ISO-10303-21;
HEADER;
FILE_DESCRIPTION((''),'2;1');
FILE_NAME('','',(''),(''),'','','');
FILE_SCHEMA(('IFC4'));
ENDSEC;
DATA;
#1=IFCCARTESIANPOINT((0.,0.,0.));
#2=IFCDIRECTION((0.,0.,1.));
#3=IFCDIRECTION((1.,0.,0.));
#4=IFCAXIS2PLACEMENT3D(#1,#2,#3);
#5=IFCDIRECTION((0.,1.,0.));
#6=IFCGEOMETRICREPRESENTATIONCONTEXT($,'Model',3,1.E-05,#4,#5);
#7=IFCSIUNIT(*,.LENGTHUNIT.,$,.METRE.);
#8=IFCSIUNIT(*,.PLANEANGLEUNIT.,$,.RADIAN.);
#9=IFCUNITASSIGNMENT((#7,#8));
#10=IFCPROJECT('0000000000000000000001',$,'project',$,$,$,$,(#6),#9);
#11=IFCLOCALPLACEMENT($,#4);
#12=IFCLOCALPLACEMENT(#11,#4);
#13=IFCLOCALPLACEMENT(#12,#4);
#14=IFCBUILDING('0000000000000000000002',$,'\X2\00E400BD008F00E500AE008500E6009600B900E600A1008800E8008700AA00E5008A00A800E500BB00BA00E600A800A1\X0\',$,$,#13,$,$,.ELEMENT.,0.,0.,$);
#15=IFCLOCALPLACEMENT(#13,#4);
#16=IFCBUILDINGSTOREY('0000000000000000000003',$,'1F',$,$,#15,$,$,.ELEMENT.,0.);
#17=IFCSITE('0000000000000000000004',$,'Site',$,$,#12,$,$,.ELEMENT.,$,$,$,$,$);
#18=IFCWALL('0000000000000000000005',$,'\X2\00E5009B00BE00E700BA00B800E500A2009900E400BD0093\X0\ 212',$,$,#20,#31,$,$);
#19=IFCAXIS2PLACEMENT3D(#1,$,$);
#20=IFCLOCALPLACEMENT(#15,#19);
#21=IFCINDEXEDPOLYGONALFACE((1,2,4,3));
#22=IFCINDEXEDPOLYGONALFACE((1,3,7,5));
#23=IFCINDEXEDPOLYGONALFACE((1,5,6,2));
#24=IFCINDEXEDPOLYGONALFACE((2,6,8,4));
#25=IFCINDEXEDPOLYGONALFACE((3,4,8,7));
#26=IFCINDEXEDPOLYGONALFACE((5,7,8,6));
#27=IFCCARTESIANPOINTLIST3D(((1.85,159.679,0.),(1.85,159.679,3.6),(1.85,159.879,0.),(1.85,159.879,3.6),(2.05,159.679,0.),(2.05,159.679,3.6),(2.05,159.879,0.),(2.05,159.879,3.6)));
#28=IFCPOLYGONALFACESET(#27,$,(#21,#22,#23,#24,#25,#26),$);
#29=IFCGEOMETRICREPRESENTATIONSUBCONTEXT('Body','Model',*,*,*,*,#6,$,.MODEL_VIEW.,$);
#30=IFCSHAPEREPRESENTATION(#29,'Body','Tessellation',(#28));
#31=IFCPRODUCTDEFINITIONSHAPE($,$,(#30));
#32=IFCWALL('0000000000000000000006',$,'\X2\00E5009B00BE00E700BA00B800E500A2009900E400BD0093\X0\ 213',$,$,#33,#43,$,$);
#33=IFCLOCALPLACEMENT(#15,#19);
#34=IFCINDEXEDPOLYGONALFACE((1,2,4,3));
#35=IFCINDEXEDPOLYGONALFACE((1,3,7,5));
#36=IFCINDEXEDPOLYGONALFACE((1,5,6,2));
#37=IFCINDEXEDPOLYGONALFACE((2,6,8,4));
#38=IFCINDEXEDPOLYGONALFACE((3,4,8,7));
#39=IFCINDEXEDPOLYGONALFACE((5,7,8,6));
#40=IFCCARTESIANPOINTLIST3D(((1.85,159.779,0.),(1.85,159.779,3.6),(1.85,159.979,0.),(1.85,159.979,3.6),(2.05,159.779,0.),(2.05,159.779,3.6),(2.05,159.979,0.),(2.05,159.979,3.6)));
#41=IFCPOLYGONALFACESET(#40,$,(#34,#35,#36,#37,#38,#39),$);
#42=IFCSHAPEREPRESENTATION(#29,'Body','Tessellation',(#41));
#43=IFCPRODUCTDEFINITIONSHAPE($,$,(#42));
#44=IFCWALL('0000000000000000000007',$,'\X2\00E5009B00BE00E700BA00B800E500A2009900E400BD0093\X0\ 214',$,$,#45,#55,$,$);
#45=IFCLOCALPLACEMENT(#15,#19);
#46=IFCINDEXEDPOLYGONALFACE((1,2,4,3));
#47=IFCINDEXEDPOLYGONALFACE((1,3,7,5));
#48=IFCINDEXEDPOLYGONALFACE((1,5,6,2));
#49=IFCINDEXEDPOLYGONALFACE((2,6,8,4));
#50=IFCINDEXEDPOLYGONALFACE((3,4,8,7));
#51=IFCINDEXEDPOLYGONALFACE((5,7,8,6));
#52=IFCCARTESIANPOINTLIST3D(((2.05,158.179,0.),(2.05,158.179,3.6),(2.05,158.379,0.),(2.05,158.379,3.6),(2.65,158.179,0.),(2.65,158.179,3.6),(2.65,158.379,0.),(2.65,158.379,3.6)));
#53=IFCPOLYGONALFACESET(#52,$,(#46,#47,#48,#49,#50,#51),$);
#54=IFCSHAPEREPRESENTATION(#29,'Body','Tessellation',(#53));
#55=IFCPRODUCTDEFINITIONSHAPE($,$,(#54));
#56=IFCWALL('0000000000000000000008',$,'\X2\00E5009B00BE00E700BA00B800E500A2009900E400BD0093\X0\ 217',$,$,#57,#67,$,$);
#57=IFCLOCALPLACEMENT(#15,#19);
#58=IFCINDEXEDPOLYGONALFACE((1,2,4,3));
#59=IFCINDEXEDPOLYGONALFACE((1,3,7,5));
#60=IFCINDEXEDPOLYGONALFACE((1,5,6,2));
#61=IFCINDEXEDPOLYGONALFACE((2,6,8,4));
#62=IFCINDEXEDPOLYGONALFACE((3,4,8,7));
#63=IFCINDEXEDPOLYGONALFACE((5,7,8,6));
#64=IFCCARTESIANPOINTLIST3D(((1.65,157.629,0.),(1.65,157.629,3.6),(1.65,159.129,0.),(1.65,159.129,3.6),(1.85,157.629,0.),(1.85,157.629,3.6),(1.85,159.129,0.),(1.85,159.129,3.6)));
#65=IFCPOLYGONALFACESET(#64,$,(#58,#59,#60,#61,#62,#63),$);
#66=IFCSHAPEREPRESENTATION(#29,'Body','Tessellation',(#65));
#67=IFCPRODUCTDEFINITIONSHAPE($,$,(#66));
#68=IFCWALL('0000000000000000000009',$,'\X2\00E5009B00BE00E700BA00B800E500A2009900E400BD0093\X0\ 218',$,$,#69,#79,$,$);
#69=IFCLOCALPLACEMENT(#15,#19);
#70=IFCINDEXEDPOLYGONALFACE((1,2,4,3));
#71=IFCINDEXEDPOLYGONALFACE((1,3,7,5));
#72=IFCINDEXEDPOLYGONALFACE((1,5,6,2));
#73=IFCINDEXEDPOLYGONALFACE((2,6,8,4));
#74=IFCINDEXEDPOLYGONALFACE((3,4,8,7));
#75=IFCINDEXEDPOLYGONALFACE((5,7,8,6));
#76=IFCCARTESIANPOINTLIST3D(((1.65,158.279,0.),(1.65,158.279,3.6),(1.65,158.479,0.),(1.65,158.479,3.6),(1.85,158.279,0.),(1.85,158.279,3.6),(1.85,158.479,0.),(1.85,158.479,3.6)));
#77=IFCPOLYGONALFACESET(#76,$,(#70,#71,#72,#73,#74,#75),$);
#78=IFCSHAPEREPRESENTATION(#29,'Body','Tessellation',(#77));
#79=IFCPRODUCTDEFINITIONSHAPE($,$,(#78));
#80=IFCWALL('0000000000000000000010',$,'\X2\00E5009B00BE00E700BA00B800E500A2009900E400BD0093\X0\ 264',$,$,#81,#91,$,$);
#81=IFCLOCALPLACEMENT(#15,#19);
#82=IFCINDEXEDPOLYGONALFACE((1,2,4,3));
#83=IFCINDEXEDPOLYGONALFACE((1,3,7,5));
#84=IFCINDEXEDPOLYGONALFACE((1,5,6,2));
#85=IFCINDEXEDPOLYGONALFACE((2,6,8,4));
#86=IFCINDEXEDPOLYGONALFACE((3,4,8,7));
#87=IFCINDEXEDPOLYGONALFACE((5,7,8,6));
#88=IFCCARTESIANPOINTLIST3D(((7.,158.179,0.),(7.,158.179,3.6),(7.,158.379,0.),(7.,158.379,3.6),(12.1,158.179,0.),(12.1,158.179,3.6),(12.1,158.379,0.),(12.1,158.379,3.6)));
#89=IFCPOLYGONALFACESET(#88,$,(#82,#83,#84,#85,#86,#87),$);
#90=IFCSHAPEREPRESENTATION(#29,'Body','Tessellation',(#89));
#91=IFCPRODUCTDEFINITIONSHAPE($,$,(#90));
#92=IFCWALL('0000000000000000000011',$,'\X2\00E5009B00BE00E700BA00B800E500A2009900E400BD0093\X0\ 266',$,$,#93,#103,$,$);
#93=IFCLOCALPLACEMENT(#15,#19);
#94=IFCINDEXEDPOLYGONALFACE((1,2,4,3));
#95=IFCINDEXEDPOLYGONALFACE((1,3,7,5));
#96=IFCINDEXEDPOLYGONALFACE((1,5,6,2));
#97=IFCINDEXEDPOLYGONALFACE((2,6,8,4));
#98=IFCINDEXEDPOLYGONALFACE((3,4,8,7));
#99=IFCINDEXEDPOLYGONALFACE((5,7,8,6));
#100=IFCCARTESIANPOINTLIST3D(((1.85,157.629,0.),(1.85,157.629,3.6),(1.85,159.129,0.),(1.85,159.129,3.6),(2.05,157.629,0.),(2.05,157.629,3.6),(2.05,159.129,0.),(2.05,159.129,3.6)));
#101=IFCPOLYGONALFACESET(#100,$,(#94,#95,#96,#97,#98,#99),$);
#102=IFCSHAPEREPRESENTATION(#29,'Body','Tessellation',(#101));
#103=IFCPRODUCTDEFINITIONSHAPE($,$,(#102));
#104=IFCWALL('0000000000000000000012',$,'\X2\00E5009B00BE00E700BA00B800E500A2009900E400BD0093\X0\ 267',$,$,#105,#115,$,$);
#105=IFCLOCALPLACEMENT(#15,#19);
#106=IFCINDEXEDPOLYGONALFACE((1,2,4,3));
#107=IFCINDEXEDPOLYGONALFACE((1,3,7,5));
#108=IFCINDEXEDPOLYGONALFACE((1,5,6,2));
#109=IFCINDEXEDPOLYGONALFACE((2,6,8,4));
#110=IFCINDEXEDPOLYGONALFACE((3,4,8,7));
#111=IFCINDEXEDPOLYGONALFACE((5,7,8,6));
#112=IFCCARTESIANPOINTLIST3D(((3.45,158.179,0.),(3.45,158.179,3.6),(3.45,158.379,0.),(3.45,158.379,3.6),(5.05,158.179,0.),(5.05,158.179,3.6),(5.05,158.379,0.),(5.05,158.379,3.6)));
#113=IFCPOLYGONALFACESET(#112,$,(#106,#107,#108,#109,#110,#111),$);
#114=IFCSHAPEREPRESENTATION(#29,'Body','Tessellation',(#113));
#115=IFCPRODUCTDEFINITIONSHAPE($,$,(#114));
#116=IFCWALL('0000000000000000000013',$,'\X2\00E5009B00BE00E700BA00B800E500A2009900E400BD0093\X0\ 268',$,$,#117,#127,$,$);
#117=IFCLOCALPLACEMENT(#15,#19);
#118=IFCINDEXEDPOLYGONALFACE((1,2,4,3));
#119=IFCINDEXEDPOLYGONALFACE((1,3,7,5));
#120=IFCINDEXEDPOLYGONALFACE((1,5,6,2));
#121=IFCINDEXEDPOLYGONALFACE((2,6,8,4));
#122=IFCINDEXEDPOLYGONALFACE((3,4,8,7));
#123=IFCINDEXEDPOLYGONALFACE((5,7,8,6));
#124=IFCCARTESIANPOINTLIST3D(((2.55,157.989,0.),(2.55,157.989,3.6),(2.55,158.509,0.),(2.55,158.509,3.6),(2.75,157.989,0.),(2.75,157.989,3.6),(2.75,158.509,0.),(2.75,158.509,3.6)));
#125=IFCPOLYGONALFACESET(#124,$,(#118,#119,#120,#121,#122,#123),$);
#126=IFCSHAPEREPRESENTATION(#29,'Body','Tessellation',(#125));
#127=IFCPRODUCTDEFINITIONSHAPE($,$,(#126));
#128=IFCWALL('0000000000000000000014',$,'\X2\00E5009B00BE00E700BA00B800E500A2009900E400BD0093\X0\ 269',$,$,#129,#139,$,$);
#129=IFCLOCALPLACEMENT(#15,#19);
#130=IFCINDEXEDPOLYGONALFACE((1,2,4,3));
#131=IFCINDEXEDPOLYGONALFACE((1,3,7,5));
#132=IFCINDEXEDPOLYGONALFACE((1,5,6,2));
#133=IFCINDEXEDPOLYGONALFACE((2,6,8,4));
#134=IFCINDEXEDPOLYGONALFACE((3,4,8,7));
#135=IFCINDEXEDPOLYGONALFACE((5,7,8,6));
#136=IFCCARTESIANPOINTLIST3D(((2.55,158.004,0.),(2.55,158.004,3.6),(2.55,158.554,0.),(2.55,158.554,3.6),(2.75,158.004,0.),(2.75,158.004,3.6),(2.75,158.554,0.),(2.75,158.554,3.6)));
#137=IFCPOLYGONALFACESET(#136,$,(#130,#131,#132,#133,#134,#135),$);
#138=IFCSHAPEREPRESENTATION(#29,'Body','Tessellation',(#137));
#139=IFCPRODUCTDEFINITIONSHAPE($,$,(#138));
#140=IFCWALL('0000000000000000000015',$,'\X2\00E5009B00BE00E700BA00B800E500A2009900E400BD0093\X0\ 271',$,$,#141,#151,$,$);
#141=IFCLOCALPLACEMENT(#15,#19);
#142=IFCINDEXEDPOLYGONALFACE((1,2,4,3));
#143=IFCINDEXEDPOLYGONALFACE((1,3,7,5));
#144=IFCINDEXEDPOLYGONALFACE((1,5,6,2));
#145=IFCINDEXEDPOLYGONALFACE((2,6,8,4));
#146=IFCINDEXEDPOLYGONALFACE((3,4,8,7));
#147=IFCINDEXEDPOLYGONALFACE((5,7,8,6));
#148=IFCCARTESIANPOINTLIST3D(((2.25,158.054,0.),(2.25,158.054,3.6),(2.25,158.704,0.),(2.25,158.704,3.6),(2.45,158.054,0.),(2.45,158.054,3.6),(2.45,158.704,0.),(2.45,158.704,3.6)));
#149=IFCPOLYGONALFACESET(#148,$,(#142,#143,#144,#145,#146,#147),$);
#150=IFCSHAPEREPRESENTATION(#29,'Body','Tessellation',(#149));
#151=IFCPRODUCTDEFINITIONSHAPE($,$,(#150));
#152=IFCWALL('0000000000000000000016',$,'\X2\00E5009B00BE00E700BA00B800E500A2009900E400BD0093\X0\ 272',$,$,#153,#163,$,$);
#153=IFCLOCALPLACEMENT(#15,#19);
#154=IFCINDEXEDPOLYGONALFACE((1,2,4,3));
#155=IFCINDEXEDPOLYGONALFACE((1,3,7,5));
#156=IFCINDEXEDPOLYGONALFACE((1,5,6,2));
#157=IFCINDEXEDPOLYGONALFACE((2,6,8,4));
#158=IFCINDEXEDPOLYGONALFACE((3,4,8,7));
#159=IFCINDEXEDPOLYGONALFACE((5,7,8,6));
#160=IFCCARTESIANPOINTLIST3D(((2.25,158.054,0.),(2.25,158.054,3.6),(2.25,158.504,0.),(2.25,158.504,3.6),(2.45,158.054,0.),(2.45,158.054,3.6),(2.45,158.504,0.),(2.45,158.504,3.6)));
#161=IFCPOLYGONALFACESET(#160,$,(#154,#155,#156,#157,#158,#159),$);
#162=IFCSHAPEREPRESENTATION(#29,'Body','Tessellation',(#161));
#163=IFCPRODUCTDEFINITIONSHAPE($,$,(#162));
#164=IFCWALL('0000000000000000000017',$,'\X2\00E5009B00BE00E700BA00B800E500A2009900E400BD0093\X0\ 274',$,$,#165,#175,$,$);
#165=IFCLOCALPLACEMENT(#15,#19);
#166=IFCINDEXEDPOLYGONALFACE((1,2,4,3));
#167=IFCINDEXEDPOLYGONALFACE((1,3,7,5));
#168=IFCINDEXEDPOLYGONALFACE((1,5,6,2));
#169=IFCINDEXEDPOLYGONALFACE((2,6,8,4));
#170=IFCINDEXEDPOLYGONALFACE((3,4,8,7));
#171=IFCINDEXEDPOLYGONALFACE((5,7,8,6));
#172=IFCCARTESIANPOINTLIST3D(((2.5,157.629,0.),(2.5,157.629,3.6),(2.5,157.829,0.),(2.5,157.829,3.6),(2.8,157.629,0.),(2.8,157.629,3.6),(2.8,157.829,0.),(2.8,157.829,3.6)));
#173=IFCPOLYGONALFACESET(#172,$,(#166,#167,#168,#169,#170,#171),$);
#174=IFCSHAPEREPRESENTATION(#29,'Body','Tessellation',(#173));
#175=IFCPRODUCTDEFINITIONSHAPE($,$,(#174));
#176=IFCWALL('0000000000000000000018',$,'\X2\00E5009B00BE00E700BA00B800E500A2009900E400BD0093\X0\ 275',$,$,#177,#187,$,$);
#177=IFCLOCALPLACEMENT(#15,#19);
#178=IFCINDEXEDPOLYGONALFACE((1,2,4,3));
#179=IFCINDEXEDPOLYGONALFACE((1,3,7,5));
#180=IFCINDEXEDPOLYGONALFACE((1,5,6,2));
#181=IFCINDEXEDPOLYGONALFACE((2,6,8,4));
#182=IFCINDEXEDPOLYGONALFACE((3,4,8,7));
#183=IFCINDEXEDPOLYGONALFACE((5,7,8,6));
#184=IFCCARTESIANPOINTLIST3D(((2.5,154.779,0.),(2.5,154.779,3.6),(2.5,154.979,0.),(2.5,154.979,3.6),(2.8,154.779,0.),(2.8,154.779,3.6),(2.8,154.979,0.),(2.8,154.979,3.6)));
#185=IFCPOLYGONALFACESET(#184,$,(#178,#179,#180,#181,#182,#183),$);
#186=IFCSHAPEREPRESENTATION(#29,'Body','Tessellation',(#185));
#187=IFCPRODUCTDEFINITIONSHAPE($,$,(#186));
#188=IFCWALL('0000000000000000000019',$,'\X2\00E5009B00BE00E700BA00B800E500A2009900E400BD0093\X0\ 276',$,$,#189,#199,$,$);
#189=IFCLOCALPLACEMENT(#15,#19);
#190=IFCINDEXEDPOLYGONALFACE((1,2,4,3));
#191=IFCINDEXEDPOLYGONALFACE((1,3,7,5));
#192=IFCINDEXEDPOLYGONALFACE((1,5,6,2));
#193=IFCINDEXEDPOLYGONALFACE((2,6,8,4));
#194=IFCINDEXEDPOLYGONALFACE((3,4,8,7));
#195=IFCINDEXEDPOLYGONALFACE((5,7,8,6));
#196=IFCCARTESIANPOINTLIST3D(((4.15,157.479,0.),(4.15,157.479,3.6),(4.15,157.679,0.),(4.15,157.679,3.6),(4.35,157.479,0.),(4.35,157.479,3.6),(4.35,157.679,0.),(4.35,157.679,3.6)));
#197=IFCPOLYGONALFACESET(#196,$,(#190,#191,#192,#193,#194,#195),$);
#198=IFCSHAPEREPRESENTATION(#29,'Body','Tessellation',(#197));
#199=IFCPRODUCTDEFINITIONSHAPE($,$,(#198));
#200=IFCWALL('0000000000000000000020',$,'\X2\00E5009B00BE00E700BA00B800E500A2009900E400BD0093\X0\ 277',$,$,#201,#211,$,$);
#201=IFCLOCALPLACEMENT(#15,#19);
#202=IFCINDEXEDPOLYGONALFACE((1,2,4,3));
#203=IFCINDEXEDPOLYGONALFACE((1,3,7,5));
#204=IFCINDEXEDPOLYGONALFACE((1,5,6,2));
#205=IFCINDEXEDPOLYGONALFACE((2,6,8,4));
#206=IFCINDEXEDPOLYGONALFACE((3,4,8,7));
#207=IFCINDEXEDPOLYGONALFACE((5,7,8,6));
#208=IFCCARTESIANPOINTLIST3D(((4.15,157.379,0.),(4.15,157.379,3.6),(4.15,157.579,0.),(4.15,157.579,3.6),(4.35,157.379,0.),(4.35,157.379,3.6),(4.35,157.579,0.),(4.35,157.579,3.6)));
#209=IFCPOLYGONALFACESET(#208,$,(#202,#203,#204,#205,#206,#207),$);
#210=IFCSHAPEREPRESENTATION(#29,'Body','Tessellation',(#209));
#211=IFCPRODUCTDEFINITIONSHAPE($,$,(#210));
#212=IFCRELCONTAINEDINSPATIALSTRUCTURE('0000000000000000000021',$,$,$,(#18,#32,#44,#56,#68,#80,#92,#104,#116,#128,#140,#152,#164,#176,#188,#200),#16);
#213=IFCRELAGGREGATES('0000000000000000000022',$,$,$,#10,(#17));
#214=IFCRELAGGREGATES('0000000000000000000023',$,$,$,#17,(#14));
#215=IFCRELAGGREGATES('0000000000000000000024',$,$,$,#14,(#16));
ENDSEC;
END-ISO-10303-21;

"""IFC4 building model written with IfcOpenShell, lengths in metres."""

from ifc_helpers import new_model, si_unit, direction, frame, frame_2d, origin_with_axes, place, context, subcontext, project, spatial, rectangle, extrude, element, save


model = new_model("IFC4")

# Units and contexts
model_context = context("Model", 3, precision=1e-05, world=origin_with_axes(), true_north=direction((0.0, 1.0, 0.0)))
body_context = subcontext(model_context, "Body", "Model", "MODEL_VIEW")
ifc_project = project(units=[si_unit("LENGTHUNIT", "METRE"), si_unit("PLANEANGLEUNIT", "RADIAN")], contexts=[model_context])

# Site, building, storey
placement = place(None, origin_with_axes())
site_placement = place(placement, origin_with_axes())
site = spatial("IfcSite", under=ifc_project, at=site_placement, Name="Site", CompositionType="ELEMENT")
building_placement = place(site_placement, origin_with_axes())
building = spatial("IfcBuilding", under=site, at=building_placement, Name="ä½\u008få®\u0085æ\u0096¹æ¡\u0088è\u0087ªå\u008a¨å»ºæ¨¡", CompositionType="ELEMENT", ElevationOfRefHeight=0.0, ElevationOfTerrain=0.0)
storey_placement = place(building_placement, origin_with_axes())
storey = spatial("IfcBuildingStorey", under=building, at=storey_placement, Name="1F", CompositionType="ELEMENT", Elevation=0.0)

# Walls
for number, where, z_axis, x_axis, name in (
    (1, (1.95, 159.779, 0.0), (0.0, 0.0, 1.0), (-1.0, 0.0, 0.0), "å\u009b¾çº¸å¢\u0099ä½\u0093 212"),
    (2, (1.95, 159.879, 0.0), (0.0, 0.0, 1.0), (-1.0, 0.0, 0.0), "å\u009b¾çº¸å¢\u0099ä½\u0093 213"),
):
    element("IfcWall", number, at=place(storey_placement, frame(where, z_axis=z_axis, x_axis=x_axis)), inside=storey, Name=name, context=body_context, shape_type="SweptSolid", body=[
        extrude(rectangle(XDim=0.2, YDim=0.2, at=frame_2d((0.0, 0.0), x_axis=(1.0, 0.0, 0.0))), frame((0.0, 0.0, 0.0), z_axis=(0.0, 0.0, 1.0)), (0.0, 0.0, 1.0), 3.6),
    ])
wall_1_placement = place(storey_placement, frame((2.35, 158.279, 0.0), z_axis=(0.0, 0.0, 1.0), x_axis=(-1.0, 0.0, 0.0)))
element("IfcWall", 3, at=wall_1_placement, inside=storey, Name="å\u009b¾çº¸å¢\u0099ä½\u0093 214", context=body_context, shape_type="SweptSolid", body=[
    extrude(rectangle(XDim=0.6, YDim=0.2, at=frame_2d((0.0, 0.0), x_axis=(1.0, 0.0, 0.0))), frame((0.0, 0.0, 0.0), z_axis=(0.0, 0.0, 1.0)), (0.0, 0.0, 1.0), 3.6),
])
wall_2_placement = place(storey_placement, frame((1.75, 158.379, 0.0), z_axis=(0.0, 0.0, 1.0), x_axis=(0.0, 1.0, 0.0)))
element("IfcWall", 4, at=wall_2_placement, inside=storey, Name="å\u009b¾çº¸å¢\u0099ä½\u0093 217", context=body_context, shape_type="SweptSolid", body=[
    extrude(rectangle(XDim=1.5, YDim=0.2, at=frame_2d((0.0, 0.0), x_axis=(1.0, 0.0, 0.0))), frame((0.0, 0.0, 0.0), z_axis=(0.0, 0.0, 1.0)), (0.0, 0.0, 1.0), 3.6),
])
wall_3_placement = place(storey_placement, frame((1.75, 158.379, 0.0), z_axis=(0.0, 0.0, 1.0), x_axis=(0.0, -1.0, 0.0)))
element("IfcWall", 5, at=wall_3_placement, inside=storey, Name="å\u009b¾çº¸å¢\u0099ä½\u0093 218", context=body_context, shape_type="SweptSolid", body=[
    extrude(rectangle(XDim=0.2, YDim=0.2, at=frame_2d((0.0, 0.0), x_axis=(1.0, 0.0, 0.0))), frame((0.0, 0.0, 0.0), z_axis=(0.0, 0.0, 1.0)), (0.0, 0.0, 1.0), 3.6),
])
wall_4_placement = place(storey_placement, frame((9.55, 158.279, 0.0), z_axis=(0.0, 0.0, 1.0), x_axis=(-1.0, 0.0, 0.0)))
element("IfcWall", 6, at=wall_4_placement, inside=storey, Name="å\u009b¾çº¸å¢\u0099ä½\u0093 264", context=body_context, shape_type="SweptSolid", body=[
    extrude(rectangle(XDim=5.1, YDim=0.2, at=frame_2d((0.0, 0.0), x_axis=(1.0, 0.0, 0.0))), frame((0.0, 0.0, 0.0), z_axis=(0.0, 0.0, 1.0)), (0.0, 0.0, 1.0), 3.6),
])
wall_5_placement = place(storey_placement, frame((1.95, 158.379, 0.0), z_axis=(0.0, 0.0, 1.0), x_axis=(0.0, 1.0, 0.0)))
element("IfcWall", 7, at=wall_5_placement, inside=storey, Name="å\u009b¾çº¸å¢\u0099ä½\u0093 266", context=body_context, shape_type="SweptSolid", body=[
    extrude(rectangle(XDim=1.5, YDim=0.2, at=frame_2d((0.0, 0.0), x_axis=(1.0, 0.0, 0.0))), frame((0.0, 0.0, 0.0), z_axis=(0.0, 0.0, 1.0)), (0.0, 0.0, 1.0), 3.6),
])
wall_6_placement = place(storey_placement, frame((4.25, 158.279, 0.0), z_axis=(0.0, 0.0, 1.0), x_axis=(-1.0, 0.0, 0.0)))
element("IfcWall", 8, at=wall_6_placement, inside=storey, Name="å\u009b¾çº¸å¢\u0099ä½\u0093 267", context=body_context, shape_type="SweptSolid", body=[
    extrude(rectangle(XDim=1.6, YDim=0.2, at=frame_2d((0.0, 0.0), x_axis=(1.0, 0.0, 0.0))), frame((0.0, 0.0, 0.0), z_axis=(0.0, 0.0, 1.0)), (0.0, 0.0, 1.0), 3.6),
])
wall_7_placement = place(storey_placement, frame((2.65, 158.249, 0.0), z_axis=(0.0, 0.0, 1.0), x_axis=(0.0, -1.0, 0.0)))
element("IfcWall", 9, at=wall_7_placement, inside=storey, Name="å\u009b¾çº¸å¢\u0099ä½\u0093 268", context=body_context, shape_type="SweptSolid", body=[
    extrude(rectangle(XDim=0.52, YDim=0.2, at=frame_2d((0.0, 0.0), x_axis=(1.0, 0.0, 0.0))), frame((0.0, 0.0, 0.0), z_axis=(0.0, 0.0, 1.0)), (0.0, 0.0, 1.0), 3.6),
])
wall_8_placement = place(storey_placement, frame((2.65, 158.279, 0.0), z_axis=(0.0, 0.0, 1.0), x_axis=(0.0, -1.0, 0.0)))
element("IfcWall", 10, at=wall_8_placement, inside=storey, Name="å\u009b¾çº¸å¢\u0099ä½\u0093 269", context=body_context, shape_type="SweptSolid", body=[
    extrude(rectangle(XDim=0.55, YDim=0.2, at=frame_2d((0.0, 0.0), x_axis=(1.0, 0.0, 0.0))), frame((0.0, 0.0, 0.0), z_axis=(0.0, 0.0, 1.0)), (0.0, 0.0, 1.0), 3.6),
])
wall_9_placement = place(storey_placement, frame((2.35, 158.379, 0.0), z_axis=(0.0, 0.0, 1.0), x_axis=(0.0, -1.0, 0.0)))
element("IfcWall", 11, at=wall_9_placement, inside=storey, Name="å\u009b¾çº¸å¢\u0099ä½\u0093 271", context=body_context, shape_type="SweptSolid", body=[
    extrude(rectangle(XDim=0.65, YDim=0.2, at=frame_2d((0.0, 0.0), x_axis=(1.0, 0.0, 0.0))), frame((0.0, 0.0, 0.0), z_axis=(0.0, 0.0, 1.0)), (0.0, 0.0, 1.0), 3.6),
])
wall_10_placement = place(storey_placement, frame((2.35, 158.279, 0.0), z_axis=(0.0, 0.0, 1.0), x_axis=(0.0, -1.0, 0.0)))
element("IfcWall", 12, at=wall_10_placement, inside=storey, Name="å\u009b¾çº¸å¢\u0099ä½\u0093 272", context=body_context, shape_type="SweptSolid", body=[
    extrude(rectangle(XDim=0.45, YDim=0.2, at=frame_2d((0.0, 0.0), x_axis=(1.0, 0.0, 0.0))), frame((0.0, 0.0, 0.0), z_axis=(0.0, 0.0, 1.0)), (0.0, 0.0, 1.0), 3.6),
])
for number, where, z_axis, x_axis, name in (
    (13, (2.65, 157.729, 0.0), (0.0, 0.0, 1.0), (-1.0, 0.0, 0.0), "å\u009b¾çº¸å¢\u0099ä½\u0093 274"),
    (14, (2.65, 154.879, 0.0), (0.0, 0.0, 1.0), (-1.0, 0.0, 0.0), "å\u009b¾çº¸å¢\u0099ä½\u0093 275"),
):
    element("IfcWall", number, at=place(storey_placement, frame(where, z_axis=z_axis, x_axis=x_axis)), inside=storey, Name=name, context=body_context, shape_type="SweptSolid", body=[
        extrude(rectangle(XDim=0.3, YDim=0.2, at=frame_2d((0.0, 0.0), x_axis=(1.0, 0.0, 0.0))), frame((0.0, 0.0, 0.0), z_axis=(0.0, 0.0, 1.0)), (0.0, 0.0, 1.0), 3.6),
    ])
for number, where, z_axis, x_axis, name in (
    (15, (4.25, 157.579, 0.0), (0.0, 0.0, 1.0), (1.0, 0.0, 0.0), "å\u009b¾çº¸å¢\u0099ä½\u0093 276"),
    (16, (4.25, 157.479, 0.0), (0.0, 0.0, 1.0), (1.0, 0.0, 0.0), "å\u009b¾çº¸å¢\u0099ä½\u0093 277"),
):
    element("IfcWall", number, at=place(storey_placement, frame(where, z_axis=z_axis, x_axis=x_axis)), inside=storey, Name=name, context=body_context, shape_type="SweptSolid", body=[
        extrude(rectangle(XDim=0.2, YDim=0.2, at=frame_2d((0.0, 0.0), x_axis=(1.0, 0.0, 0.0))), frame((0.0, 0.0, 0.0), z_axis=(0.0, 0.0, 1.0)), (0.0, 0.0, 1.0), 3.6),
    ])

save(model, "model.ifc")
